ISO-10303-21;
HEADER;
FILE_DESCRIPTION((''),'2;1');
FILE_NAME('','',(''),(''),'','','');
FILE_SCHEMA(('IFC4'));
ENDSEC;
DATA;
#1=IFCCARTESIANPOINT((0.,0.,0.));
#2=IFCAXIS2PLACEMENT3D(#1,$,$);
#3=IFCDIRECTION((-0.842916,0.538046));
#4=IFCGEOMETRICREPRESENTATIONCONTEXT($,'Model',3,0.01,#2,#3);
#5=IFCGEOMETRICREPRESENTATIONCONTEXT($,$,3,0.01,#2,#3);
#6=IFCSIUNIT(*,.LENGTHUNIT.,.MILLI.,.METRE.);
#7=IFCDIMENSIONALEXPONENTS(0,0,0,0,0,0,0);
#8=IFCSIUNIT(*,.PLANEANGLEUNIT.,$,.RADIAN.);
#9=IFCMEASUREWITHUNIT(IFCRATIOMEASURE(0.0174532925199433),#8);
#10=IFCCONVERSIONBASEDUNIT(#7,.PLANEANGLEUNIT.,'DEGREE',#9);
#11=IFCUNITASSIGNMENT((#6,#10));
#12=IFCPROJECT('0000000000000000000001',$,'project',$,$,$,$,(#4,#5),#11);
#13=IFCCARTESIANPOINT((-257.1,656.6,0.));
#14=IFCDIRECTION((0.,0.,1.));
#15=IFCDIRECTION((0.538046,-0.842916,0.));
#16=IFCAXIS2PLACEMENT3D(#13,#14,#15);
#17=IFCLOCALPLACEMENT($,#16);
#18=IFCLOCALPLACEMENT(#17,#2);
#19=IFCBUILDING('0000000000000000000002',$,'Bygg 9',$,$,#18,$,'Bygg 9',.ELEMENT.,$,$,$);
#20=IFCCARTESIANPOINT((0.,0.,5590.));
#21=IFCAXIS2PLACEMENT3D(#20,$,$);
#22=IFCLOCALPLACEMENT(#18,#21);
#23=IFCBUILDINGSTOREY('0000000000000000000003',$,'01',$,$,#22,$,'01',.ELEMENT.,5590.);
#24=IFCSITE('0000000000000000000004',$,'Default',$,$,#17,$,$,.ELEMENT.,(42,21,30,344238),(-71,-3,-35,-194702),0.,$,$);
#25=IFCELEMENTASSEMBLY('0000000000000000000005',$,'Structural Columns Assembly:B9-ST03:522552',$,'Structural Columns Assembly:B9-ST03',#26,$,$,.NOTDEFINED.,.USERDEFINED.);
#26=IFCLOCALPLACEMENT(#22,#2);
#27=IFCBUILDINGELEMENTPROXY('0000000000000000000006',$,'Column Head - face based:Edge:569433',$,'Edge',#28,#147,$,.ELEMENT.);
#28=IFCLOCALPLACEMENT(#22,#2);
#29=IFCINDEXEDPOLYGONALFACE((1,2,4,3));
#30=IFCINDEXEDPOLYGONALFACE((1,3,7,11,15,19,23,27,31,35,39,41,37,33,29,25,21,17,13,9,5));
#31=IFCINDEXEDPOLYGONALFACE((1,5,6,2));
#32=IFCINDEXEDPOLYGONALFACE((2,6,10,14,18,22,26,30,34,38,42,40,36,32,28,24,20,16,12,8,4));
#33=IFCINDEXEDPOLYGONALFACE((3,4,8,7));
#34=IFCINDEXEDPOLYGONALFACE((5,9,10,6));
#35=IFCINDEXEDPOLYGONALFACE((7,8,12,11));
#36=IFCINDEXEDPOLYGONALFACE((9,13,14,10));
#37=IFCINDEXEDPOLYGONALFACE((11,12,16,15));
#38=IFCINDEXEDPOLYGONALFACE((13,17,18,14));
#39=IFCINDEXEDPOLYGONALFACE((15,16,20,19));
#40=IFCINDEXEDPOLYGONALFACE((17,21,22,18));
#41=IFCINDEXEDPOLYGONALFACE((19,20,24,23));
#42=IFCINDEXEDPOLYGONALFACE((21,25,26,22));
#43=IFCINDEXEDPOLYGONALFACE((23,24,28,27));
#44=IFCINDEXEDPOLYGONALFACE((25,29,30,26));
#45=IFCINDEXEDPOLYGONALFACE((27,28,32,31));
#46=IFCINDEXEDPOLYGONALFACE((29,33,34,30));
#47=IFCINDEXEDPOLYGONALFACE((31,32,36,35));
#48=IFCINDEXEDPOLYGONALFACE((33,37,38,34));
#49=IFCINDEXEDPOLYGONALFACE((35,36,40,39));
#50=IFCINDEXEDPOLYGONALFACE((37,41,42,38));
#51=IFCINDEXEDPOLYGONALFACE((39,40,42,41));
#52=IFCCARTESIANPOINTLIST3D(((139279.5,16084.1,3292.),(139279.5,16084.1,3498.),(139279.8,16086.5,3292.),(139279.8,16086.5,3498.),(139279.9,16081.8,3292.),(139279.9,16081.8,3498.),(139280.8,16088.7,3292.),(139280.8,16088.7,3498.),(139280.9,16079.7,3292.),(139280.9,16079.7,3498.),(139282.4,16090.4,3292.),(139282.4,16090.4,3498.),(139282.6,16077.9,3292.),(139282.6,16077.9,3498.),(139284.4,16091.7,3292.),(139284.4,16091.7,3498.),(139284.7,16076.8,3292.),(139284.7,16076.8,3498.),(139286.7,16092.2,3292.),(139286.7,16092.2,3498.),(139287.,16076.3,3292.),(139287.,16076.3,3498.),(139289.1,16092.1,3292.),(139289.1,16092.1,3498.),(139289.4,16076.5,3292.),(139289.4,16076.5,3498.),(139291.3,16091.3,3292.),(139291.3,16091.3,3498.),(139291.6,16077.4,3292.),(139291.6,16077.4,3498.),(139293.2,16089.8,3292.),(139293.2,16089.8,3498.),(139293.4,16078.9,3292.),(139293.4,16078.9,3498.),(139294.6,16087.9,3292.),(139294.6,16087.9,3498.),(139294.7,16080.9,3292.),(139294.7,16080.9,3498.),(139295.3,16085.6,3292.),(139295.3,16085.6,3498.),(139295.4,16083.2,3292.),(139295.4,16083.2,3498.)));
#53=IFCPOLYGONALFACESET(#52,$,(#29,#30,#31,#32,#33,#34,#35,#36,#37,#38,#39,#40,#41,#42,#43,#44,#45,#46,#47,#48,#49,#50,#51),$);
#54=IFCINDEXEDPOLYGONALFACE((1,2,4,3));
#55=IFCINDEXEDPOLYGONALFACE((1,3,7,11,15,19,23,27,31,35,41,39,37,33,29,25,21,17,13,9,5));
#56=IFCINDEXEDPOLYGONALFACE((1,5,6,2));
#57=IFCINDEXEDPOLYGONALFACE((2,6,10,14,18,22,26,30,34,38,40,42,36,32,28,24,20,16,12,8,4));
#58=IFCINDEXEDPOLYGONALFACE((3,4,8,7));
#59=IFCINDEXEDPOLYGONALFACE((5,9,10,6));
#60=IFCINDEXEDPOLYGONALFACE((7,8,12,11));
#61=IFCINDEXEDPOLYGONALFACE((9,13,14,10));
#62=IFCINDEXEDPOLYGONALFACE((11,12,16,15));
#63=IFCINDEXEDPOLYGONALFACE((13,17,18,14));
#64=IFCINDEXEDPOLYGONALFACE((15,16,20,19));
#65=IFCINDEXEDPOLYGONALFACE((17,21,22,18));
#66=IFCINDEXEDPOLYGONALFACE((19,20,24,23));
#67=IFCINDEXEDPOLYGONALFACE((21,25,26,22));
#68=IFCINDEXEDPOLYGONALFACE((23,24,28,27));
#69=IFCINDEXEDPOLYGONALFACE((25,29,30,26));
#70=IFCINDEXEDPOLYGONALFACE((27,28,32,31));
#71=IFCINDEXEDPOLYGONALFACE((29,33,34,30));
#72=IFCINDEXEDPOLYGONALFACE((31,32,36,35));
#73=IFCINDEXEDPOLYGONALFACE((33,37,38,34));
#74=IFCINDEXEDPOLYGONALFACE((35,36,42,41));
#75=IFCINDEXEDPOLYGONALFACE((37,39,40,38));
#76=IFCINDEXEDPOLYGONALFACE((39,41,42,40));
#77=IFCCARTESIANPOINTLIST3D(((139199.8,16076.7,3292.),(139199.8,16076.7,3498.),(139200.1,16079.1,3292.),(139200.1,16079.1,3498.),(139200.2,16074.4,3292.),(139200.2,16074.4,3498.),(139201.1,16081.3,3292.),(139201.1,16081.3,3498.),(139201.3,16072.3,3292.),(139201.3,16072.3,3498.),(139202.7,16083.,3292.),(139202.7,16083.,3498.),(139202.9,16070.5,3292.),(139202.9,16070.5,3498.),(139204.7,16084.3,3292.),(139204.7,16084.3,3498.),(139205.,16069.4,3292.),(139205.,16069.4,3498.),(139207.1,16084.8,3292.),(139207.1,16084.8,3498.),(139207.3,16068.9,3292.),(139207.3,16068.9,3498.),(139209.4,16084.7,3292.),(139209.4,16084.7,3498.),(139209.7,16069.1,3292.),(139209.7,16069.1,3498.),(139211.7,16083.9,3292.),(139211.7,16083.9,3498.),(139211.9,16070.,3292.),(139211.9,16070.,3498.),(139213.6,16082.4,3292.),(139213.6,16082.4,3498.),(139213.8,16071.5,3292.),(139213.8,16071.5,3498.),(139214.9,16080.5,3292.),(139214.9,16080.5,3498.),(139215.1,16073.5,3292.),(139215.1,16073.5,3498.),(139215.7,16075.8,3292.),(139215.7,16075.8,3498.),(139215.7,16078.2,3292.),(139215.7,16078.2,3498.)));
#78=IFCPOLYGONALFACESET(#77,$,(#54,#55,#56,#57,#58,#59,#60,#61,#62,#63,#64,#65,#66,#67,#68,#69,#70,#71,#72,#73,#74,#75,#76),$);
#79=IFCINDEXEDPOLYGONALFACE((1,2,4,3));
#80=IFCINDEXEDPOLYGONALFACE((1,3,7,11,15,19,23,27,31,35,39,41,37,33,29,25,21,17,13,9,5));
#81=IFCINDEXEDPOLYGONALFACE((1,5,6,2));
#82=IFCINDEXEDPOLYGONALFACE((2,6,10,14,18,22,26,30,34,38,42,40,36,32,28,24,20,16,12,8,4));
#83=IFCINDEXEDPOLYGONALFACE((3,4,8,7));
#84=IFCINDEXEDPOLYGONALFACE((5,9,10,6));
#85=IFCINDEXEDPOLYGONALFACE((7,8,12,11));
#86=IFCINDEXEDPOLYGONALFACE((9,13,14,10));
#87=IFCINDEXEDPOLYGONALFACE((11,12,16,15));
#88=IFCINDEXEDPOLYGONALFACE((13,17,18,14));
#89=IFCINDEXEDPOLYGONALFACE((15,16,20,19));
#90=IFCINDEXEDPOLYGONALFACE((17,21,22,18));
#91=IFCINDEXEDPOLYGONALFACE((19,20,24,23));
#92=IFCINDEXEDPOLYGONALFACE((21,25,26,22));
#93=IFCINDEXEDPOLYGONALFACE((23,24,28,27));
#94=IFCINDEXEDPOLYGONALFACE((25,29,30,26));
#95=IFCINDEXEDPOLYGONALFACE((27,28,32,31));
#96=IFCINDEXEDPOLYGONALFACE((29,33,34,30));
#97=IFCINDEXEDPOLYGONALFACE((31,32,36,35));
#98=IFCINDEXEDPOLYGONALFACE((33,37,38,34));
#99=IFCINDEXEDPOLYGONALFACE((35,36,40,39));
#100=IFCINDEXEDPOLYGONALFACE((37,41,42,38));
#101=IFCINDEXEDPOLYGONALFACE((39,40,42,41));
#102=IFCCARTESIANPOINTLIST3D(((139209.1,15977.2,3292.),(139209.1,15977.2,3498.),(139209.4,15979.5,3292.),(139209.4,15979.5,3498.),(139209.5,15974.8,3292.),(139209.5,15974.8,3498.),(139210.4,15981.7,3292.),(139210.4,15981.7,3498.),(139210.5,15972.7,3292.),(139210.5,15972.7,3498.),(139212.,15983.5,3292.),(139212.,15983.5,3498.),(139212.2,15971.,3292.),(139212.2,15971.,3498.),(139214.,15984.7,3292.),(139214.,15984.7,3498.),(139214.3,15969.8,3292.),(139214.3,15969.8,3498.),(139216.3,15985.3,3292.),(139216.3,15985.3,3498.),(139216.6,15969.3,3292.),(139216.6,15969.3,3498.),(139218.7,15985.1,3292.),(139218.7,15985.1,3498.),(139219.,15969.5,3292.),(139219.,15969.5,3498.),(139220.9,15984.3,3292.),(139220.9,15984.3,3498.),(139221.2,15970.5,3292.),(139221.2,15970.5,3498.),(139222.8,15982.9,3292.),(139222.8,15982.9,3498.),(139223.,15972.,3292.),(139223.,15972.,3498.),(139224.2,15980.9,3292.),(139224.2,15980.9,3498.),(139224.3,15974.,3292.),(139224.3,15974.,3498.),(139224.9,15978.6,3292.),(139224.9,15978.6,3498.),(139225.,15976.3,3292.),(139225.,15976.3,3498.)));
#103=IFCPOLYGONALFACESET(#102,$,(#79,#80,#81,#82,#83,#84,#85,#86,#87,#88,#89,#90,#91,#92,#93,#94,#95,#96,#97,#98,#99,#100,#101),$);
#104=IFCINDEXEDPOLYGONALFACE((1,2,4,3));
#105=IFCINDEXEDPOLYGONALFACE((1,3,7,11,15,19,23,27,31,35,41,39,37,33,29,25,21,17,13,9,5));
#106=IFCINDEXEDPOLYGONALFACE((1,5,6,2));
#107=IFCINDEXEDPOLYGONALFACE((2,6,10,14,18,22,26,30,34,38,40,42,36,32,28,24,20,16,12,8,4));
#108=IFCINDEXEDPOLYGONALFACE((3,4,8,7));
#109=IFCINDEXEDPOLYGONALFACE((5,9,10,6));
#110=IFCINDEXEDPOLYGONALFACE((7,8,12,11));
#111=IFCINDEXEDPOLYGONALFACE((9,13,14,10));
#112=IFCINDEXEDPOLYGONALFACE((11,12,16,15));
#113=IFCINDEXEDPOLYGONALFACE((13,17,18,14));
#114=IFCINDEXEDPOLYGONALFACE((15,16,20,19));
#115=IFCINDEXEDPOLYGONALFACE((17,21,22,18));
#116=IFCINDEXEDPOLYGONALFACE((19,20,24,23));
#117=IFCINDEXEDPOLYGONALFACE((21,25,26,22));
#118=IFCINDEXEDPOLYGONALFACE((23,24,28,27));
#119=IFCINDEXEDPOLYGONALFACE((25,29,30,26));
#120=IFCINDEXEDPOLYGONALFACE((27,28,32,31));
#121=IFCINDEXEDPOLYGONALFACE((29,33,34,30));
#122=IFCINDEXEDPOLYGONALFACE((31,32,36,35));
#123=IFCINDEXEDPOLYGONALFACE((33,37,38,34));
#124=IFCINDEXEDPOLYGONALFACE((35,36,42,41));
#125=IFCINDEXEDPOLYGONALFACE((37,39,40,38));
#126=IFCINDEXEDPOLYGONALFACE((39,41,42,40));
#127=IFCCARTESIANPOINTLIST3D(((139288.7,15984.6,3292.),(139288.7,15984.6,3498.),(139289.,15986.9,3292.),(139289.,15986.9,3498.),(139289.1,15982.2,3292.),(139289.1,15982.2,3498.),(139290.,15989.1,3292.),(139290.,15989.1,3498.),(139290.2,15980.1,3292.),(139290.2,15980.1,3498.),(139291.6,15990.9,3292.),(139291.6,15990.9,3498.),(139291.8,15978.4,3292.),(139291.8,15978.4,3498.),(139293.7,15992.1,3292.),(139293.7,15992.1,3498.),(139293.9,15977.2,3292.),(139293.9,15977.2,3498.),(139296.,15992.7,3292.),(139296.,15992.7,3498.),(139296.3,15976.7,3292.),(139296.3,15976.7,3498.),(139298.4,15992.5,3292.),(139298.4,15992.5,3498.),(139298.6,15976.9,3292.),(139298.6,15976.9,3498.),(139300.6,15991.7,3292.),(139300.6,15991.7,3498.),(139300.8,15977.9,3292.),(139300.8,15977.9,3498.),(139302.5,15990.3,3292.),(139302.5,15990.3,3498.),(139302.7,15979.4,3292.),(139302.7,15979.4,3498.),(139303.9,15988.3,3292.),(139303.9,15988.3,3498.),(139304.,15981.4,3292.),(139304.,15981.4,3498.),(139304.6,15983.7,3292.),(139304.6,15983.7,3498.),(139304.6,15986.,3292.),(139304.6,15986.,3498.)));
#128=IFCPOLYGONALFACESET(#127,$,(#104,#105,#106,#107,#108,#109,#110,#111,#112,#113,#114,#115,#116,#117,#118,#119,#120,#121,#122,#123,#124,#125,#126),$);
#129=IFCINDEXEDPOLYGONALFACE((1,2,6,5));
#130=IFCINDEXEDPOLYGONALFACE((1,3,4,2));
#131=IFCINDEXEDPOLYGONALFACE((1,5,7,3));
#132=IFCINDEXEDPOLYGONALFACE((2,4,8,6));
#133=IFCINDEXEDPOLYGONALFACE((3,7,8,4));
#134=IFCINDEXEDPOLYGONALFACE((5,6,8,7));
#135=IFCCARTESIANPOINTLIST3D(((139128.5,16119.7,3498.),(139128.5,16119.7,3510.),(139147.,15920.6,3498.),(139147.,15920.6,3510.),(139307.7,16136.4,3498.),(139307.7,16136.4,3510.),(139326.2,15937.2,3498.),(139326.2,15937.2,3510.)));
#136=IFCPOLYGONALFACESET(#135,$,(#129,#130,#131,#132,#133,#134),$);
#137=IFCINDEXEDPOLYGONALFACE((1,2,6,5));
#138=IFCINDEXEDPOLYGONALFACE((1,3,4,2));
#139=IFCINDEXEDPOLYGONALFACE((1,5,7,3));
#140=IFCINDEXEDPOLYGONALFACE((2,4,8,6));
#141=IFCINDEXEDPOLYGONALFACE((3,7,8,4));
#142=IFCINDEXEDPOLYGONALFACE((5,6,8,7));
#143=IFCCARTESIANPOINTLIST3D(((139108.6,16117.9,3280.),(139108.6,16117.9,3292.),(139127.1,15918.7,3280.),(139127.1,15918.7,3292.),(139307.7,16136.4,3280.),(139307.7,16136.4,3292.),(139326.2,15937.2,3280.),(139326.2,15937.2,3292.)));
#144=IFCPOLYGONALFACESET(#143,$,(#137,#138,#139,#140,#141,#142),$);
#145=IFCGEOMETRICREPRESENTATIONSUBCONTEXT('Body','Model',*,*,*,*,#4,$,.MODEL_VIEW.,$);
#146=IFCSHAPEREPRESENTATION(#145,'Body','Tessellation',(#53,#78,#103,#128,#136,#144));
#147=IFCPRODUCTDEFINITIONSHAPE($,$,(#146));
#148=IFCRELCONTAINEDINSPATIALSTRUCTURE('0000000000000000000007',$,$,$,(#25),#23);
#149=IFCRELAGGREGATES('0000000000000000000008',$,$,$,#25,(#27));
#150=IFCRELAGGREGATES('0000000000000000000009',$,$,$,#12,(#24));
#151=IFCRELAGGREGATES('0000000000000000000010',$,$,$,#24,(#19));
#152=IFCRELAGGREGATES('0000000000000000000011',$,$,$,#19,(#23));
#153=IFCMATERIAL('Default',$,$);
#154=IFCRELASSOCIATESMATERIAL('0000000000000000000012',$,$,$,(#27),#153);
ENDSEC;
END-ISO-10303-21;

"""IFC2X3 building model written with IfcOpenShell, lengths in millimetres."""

from ifc_helpers import new_model, entity, si_unit, converted_unit, direction, frame, frame_2d, origin, origin_2d_with_axis, place, context, subcontext, project, spatial, rectangle, circle, extrude, source, transform, mapped, material, element, aggregate, save


model = new_model("IFC2X3")

# Units and contexts
model_context = context("Model", 3, precision=0.01, world=origin(), true_north=direction((-0.842916, 0.538046)))
context_of_model = context(None, 3, precision=0.01, world=origin(), true_north=direction((-0.842916, 0.538046)))
body_context = subcontext(model_context, "Body", "Model", "MODEL_VIEW")
ifc_project = project(units=[si_unit("LENGTHUNIT", "METRE", prefix="MILLI"), converted_unit("PLANEANGLEUNIT", "DEGREE", entity("IfcRatioMeasure", 0.0174532925199433), si_unit("PLANEANGLEUNIT", "RADIAN"), dimensions=[0, 0, 0, 0, 0, 0, 0])], contexts=[model_context, context_of_model])

# Site, building, storey
site_placement = place(None, frame((-257.1, 656.6, 0.0), z_axis=(0.0, 0.0, 1.0), x_axis=(0.538046, -0.842916, 0.0)))
site = spatial("IfcSite", under=ifc_project, at=site_placement, Name="Default", CompositionType="ELEMENT", RefLatitude=(42, 21, 30, 344238), RefLongitude=(-71, -3, -35, -194702), RefElevation=0.0)
building_placement = place(site_placement, origin())
building = spatial("IfcBuilding", under=site, at=building_placement, Name="Bygg 9", LongName="Bygg 9", CompositionType="ELEMENT")
storey_placement = place(building_placement, frame((0.0, 0.0, 5590.0)))
storey = spatial("IfcBuildingStorey", under=building, at=storey_placement, Name="01", LongName="01", CompositionType="ELEMENT", Elevation=5590.0)

# Element assembly, building element proxy
ifc_material_1 = material(Name="Default")
shared_shape_1 = source(origin(), body_context, "Body", "SweptSolid", [
    extrude(circle(Radius=8.0, at=frame_2d((0.0, 0.0), x_axis=(1.0, 0.0))), frame((50.0, -135.0, 12.0)), (0.0, 0.0, 1.0), 206.0),
    extrude(circle(Radius=8.0, at=frame_2d((0.0, 0.0), x_axis=(1.0, 0.0))), frame((50.0, -55.0, 12.0)), (0.0, 0.0, 1.0), 206.0),
    extrude(circle(Radius=8.0, at=frame_2d((0.0, 0.0), x_axis=(1.0, 0.0))), frame((-50.0, -55.0, 12.0)), (0.0, 0.0, 1.0), 206.0),
    extrude(circle(Radius=8.0, at=frame_2d((0.0, 0.0), x_axis=(1.0, 0.0))), frame((-50.0, -135.0, 12.0)), (0.0, 0.0, 1.0), 206.0),
    extrude(rectangle(XDim=200.0, YDim=180.0, at=origin_2d_with_axis()), frame((0.0, -70.0, 218.0), z_axis=(0.0, 0.0, 1.0), x_axis=(-1.0, 0.0, 0.0)), (0.0, 0.0, 1.0), 12.0),
    extrude(rectangle(XDim=200.0, YDim=200.0, at=origin_2d_with_axis()), frame((0.0, -60.0, 0.0), z_axis=(0.0, 0.0, 1.0), x_axis=(0.0, 1.0, 0.0)), (0.0, 0.0, 1.0), 12.0),
])
assembly_1_placement = place(storey_placement, origin())
assembly_1 = element("IfcElementAssembly", 1, at=assembly_1_placement, inside=storey, Name="Structural Columns Assembly:B9-ST03:522552", ObjectType="Structural Columns Assembly:B9-ST03", AssemblyPlace="NOTDEFINED", PredefinedType="USERDEFINED")
proxy_1_placement = place(assembly_1_placement, frame((139157.7, 16022.0, 3280.0), z_axis=(0.0, 0.0, 1.0), x_axis=(-0.092535, 0.995709, 0.0)))
proxy_1 = element("IfcBuildingElementProxy", 2, at=proxy_1_placement, material=ifc_material_1, Name="Column Head - face based:Edge:569433", ObjectType="Edge", CompositionType="ELEMENT", context=body_context, shape_type="MappedRepresentation", body=[
    mapped(shared_shape_1, transform((0.0, 0.0, 0.0), scale=1.0)),
])
aggregate(assembly_1, [proxy_1])

save(model, "model.ifc")
